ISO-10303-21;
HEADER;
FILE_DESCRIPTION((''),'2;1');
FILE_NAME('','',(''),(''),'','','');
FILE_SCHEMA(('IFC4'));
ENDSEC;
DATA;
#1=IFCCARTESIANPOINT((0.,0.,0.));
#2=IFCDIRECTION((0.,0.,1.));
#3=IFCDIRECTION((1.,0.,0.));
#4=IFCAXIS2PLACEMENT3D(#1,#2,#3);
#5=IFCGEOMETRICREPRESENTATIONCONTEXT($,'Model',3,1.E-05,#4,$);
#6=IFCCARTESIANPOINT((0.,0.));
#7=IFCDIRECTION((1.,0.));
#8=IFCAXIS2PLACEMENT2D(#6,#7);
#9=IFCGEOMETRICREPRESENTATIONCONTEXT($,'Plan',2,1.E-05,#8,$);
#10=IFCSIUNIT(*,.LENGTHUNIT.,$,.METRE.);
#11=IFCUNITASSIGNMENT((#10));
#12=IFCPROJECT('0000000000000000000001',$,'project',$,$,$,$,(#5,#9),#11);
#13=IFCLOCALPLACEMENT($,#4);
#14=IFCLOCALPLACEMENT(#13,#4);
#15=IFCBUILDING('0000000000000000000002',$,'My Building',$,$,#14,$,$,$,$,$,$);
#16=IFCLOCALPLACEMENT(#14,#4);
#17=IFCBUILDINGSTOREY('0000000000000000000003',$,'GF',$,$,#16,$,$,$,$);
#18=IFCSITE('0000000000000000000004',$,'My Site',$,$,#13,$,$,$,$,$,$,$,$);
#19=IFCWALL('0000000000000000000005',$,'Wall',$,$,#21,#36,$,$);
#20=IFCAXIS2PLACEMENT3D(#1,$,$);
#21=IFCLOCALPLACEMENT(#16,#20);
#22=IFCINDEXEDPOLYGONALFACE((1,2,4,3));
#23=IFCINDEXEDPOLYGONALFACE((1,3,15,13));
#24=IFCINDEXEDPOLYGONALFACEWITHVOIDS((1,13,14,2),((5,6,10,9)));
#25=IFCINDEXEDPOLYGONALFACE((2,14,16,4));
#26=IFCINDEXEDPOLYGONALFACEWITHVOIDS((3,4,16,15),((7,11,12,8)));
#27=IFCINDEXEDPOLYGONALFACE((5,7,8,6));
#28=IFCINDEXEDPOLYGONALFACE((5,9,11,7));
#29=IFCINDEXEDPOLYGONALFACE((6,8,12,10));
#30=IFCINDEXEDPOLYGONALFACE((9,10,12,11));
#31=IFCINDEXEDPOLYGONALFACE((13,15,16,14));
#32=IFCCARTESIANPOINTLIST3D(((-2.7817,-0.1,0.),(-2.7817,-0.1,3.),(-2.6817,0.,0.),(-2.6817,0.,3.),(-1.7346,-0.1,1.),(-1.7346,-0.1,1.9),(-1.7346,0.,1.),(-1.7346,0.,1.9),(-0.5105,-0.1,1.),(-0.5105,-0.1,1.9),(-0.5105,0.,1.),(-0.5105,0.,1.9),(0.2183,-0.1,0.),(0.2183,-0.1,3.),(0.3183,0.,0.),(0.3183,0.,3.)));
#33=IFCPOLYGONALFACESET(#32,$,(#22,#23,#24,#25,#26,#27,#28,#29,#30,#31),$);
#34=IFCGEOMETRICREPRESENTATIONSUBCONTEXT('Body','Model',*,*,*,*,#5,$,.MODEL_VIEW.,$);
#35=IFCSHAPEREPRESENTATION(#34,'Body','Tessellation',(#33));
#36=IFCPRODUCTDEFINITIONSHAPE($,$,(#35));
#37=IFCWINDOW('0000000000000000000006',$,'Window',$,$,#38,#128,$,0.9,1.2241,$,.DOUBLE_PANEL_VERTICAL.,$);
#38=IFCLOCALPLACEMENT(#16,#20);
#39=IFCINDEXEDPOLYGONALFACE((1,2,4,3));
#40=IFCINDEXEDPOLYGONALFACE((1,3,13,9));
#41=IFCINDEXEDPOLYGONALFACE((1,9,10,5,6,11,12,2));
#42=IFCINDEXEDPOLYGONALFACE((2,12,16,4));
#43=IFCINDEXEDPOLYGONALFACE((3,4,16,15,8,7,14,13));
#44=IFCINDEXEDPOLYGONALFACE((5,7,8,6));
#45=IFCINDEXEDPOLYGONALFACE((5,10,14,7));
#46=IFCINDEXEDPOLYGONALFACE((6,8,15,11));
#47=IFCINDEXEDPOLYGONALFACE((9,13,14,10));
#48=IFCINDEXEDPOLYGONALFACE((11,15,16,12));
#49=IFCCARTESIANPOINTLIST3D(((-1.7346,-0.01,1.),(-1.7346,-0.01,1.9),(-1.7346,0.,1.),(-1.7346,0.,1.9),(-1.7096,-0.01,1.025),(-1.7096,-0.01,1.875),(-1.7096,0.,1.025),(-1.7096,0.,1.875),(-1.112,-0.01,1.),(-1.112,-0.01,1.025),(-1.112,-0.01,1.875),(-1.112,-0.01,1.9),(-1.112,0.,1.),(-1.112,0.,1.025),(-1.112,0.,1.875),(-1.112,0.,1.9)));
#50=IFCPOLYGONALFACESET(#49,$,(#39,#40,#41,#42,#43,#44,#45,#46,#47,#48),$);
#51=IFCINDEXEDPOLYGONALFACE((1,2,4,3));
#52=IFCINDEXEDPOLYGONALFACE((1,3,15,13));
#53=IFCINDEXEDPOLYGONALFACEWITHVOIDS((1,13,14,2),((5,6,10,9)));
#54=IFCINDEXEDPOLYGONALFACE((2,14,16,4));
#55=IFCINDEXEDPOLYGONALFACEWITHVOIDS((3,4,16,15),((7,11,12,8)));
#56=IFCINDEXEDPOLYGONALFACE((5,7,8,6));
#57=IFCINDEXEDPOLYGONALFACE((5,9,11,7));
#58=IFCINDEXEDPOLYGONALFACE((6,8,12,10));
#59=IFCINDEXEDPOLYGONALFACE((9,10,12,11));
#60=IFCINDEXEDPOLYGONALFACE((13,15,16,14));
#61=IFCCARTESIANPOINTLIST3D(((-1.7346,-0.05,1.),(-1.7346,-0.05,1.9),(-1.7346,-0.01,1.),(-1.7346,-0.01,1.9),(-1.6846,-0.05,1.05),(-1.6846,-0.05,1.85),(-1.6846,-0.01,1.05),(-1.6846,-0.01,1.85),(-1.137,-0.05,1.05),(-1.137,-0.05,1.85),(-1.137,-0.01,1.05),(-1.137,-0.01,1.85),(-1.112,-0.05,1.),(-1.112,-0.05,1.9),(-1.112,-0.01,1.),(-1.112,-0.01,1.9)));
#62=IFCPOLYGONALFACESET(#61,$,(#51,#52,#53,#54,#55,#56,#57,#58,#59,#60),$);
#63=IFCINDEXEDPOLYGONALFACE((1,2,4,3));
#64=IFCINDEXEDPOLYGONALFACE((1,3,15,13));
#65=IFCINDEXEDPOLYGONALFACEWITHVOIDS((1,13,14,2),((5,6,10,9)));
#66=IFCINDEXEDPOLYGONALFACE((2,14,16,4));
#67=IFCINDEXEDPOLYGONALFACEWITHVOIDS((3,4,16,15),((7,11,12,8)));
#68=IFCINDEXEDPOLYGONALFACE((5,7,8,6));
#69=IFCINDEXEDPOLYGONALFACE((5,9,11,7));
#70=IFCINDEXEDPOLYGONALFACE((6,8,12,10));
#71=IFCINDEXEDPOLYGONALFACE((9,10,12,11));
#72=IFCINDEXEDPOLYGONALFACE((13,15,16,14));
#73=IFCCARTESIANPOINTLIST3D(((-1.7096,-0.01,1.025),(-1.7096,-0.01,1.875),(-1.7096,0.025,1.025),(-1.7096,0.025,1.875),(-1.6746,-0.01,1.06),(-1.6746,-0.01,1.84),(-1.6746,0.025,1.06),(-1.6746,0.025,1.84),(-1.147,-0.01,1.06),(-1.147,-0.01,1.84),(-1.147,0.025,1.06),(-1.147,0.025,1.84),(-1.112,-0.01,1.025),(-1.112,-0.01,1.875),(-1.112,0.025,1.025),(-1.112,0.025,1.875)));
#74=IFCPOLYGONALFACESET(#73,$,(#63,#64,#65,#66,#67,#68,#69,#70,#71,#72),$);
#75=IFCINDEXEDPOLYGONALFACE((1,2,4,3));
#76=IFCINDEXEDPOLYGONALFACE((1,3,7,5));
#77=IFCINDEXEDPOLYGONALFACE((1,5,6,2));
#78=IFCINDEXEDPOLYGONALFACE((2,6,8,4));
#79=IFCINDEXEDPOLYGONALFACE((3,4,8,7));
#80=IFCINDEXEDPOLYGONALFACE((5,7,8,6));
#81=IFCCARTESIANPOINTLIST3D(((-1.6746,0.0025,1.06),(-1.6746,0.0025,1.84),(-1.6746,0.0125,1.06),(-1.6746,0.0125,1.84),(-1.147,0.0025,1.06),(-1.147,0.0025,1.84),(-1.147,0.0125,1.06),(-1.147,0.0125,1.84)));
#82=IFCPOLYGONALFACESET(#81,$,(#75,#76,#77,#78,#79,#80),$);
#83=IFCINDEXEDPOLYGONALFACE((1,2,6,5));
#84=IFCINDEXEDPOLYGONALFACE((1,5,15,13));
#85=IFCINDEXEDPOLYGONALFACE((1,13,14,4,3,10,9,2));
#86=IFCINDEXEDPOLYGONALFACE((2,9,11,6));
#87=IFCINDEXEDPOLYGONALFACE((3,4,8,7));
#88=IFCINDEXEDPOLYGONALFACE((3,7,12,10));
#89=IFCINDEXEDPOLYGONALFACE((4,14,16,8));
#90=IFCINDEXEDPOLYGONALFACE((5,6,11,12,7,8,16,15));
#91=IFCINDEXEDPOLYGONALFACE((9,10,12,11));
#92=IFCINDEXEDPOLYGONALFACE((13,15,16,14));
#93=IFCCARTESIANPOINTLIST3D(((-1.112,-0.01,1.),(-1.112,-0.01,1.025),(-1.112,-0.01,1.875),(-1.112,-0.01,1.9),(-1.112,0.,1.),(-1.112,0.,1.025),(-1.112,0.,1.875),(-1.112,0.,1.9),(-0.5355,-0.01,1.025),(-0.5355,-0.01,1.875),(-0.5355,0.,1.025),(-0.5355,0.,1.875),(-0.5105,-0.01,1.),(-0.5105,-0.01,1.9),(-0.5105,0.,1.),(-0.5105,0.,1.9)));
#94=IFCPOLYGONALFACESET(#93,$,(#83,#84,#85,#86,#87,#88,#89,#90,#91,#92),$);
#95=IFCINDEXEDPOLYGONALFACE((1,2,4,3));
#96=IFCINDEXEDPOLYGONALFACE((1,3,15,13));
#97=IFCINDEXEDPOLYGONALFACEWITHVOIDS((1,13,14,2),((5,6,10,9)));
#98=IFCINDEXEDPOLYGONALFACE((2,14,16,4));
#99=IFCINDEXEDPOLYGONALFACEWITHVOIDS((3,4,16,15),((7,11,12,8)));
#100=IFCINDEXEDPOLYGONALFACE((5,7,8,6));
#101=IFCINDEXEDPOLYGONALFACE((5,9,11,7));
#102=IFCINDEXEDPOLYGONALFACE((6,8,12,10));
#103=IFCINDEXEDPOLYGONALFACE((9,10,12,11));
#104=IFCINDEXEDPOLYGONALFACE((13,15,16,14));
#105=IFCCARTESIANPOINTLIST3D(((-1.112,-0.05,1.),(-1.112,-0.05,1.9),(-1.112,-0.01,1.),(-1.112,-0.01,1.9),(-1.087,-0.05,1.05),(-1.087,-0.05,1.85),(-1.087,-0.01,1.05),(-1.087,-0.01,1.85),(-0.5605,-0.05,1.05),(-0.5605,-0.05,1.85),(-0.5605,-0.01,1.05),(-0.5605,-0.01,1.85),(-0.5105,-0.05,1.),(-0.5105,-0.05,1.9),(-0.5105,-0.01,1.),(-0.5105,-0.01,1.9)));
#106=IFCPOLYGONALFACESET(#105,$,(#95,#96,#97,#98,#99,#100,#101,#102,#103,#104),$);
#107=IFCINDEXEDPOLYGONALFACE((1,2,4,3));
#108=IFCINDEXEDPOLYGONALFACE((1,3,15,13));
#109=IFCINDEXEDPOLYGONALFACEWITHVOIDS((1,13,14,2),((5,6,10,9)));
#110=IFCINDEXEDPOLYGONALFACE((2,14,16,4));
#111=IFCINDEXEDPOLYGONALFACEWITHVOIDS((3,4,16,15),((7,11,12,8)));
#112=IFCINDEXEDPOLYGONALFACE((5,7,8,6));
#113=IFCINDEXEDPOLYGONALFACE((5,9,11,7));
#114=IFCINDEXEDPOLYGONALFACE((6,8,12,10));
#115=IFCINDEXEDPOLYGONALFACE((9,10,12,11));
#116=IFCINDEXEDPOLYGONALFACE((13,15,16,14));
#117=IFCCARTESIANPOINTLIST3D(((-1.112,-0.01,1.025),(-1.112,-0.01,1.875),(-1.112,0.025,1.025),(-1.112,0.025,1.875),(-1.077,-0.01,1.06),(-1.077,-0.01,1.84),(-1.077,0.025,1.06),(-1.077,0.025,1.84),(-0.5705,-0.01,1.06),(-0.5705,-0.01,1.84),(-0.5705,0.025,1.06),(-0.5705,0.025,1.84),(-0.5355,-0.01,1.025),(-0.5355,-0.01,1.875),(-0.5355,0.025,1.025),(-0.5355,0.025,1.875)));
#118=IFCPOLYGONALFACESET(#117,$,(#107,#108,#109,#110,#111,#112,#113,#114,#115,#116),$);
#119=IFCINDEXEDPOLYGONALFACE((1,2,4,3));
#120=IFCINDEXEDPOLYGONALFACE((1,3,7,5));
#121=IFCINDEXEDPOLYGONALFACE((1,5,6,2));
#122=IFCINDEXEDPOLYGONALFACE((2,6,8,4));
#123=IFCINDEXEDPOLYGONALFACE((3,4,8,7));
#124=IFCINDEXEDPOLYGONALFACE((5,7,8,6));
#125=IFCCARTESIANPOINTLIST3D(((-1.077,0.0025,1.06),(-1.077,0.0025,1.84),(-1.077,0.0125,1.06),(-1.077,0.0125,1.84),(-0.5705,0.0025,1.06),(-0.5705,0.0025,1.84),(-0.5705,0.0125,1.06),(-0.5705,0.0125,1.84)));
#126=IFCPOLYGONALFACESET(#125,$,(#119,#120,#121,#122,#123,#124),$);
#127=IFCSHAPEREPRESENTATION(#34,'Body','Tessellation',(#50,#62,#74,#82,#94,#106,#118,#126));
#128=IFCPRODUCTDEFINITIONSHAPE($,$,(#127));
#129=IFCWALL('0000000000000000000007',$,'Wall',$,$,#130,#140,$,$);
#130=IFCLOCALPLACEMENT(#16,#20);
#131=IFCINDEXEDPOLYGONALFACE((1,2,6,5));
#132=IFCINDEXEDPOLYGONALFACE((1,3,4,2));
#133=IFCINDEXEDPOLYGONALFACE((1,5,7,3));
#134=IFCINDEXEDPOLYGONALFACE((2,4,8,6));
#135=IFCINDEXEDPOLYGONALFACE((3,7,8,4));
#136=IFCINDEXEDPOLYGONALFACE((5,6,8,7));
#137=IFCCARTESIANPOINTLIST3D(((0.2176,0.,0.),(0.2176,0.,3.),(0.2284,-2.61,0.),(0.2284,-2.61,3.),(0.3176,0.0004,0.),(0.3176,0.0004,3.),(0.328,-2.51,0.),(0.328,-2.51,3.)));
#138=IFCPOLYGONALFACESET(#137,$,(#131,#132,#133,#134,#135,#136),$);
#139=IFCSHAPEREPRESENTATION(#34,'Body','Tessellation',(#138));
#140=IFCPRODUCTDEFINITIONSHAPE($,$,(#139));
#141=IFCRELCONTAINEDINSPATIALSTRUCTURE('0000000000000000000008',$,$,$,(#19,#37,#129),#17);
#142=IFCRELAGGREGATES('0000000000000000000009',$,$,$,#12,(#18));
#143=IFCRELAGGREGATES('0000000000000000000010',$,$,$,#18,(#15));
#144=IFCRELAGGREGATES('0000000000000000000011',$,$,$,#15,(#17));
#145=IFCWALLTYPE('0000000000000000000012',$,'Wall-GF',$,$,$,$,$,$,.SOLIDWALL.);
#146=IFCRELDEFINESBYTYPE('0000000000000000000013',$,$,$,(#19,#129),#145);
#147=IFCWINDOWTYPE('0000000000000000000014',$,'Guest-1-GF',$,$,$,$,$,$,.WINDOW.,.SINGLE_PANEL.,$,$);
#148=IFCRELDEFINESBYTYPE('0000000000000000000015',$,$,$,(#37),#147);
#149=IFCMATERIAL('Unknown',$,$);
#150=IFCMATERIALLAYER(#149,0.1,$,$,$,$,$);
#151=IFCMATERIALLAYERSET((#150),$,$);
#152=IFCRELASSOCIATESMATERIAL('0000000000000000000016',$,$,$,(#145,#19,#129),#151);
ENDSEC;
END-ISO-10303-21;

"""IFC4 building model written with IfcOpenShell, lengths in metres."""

from ifc_helpers import new_model, entity, si_unit, frame, origin_with_axes, origin_2d_with_axis, place, context, subcontext, project, spatial, line, indexed_curve, outline, extrude, shape, source, transform, mapped, material, layer, layer_set, layer_usage, type_object, type_shapes, element, fill, save


model = new_model("IFC4")

# Units and contexts
model_context = context("Model", 3, precision=1e-05, world=origin_with_axes())
plan_context = context("Plan", 2, precision=1e-05, world=origin_2d_with_axis())
body_context_1 = subcontext(model_context, "Body", "Model", "MODEL_VIEW")
body_context_2 = subcontext(plan_context, "Body", "Plan", "PLAN_VIEW")
ifc_project = project(units=[si_unit("LENGTHUNIT", "METRE")], contexts=[model_context, plan_context])

# Site, building, storey
site_placement = place(None, origin_with_axes())
site = spatial("IfcSite", under=ifc_project, at=site_placement, Name="My Site")
building_placement = place(site_placement, origin_with_axes())
building = spatial("IfcBuilding", under=site, at=building_placement, Name="My Building")
storey_placement = place(building_placement, origin_with_axes())
storey = spatial("IfcBuildingStorey", under=building, at=storey_placement, Name="GF")

# Shared definitions
ifc_material_1 = material(Name="Unknown")

# Shared definitions
ifc_layer_1 = layer(ifc_material_1, 0.1)
ifc_layer_set_1 = layer_set([ifc_layer_1])
wall_type = type_object("IfcWallType", Name="Wall-GF", PredefinedType="SOLIDWALL", material=ifc_layer_set_1)

# Wall, opening, window
ifc_layer_usage_1 = layer_usage(ifc_layer_set_1, "AXIS2", "POSITIVE", 0.0)
wall_1_placement = place(storey_placement, frame((-2.7817, -0.1, 0.0), z_axis=(0.0, 0.0, 1.0), x_axis=(1.0, 0.0, 0.0)))
wall_1 = element("IfcWall", 1, at=wall_1_placement, inside=storey, type_object=wall_type, material=ifc_layer_usage_1, Name="Wall", context=body_context_1, shape_type="SweptSolid", body=[
    extrude(outline(indexed_curve([(0.0, 0.0), (0.1, 0.1), (3.1, 0.1), (3.0, 0.0)], segments=[line(1, 2, 3, 4, 1)])), origin_with_axes(), (0.0, 0.0, 1.0), 3.0),
])
shared_shape_1 = source(origin_with_axes(), body_context_1, "Body", "SweptSolid", [
    extrude(outline(indexed_curve([(0.0, 0.0), (1.2241, 0.0), (1.2241, 0.9), (0.0, 0.9)], segments=[line(1, 2, 3, 4, 1)])), frame((0.0, -0.6, 0.0), z_axis=(0.0, -1.0, 0.0), x_axis=(1.0, 0.0, 0.0)), (0.0, 0.0, -1.0), 1.2),
])
opening_1_placement = place(wall_1_placement, frame((1.0471, 0.0, 1.0), z_axis=(0.0, 0.0, 1.0), x_axis=(1.0, 0.0, 0.0)))
opening_1 = element("IfcOpeningElement", 2, at=opening_1_placement, cuts=wall_1, PredefinedType="OPENING", context=body_context_1, shape_type="MappedRepresentation", body=[
    mapped(shared_shape_1, transform((0.0, 0.0, 0.0), x_axis=(1.0, 0.0, 0.0), y_axis=(0.0, 1.0, 0.0), z_axis=(0.0, 0.0, 1.0), scale=1.0)),
])
window_type_1 = type_object("IfcWindowType", Name="Guest-1-GF", PartitioningType="SINGLE_PANEL", PredefinedType="WINDOW")
shared_shape_2 = source(origin_with_axes(), body_context_1, "Body", "SweptSolid", [
    extrude(outline(indexed_curve([(0.6225, 0.0), (0.0, 0.0), (0.0, 0.9), (0.6225, 0.9), (0.6225, 0.875), (0.025, 0.875), (0.025, 0.025), (0.6225, 0.025)], segments=[line(1, 2, 3, 4, 5, 6, 7, 8, 1)])), frame((0.0, 0.09, 0.0), z_axis=(0.0, -1.0, 0.0), x_axis=(1.0, 0.0, 0.0)), (0.0, 0.0, -1.0), 0.01),
    extrude(outline(indexed_curve([(0.0, 0.0), (0.6225, 0.0), (0.6225, 0.9), (0.0, 0.9)], segments=[line(1, 2, 3, 4, 1)]), holes=[indexed_curve([(0.05, 0.05), (0.5975, 0.05), (0.5975, 0.85), (0.05, 0.85)], segments=[line(1, 2, 3, 4, 1)])]), frame((0.0, 0.05, 0.0), z_axis=(0.0, -1.0, 0.0), x_axis=(1.0, 0.0, 0.0)), (0.0, 0.0, -1.0), 0.04),
    extrude(outline(indexed_curve([(0.0, 0.0), (0.5975, 0.0), (0.5975, 0.85), (0.0, 0.85)], segments=[line(1, 2, 3, 4, 1)]), holes=[indexed_curve([(0.035, 0.035), (0.5625, 0.035), (0.5625, 0.815), (0.035, 0.815)], segments=[line(1, 2, 3, 4, 1)])]), frame((0.025, 0.09, 0.025), z_axis=(0.0, -1.0, 0.0), x_axis=(1.0, 0.0, 0.0)), (0.0, 0.0, -1.0), 0.035),
    extrude(outline(indexed_curve([(0.035, 0.035), (0.5625, 0.035), (0.5625, 0.815), (0.035, 0.815)], segments=[line(1, 2, 3, 4, 1)])), frame((0.025, 0.1025, 0.025), z_axis=(0.0, -1.0, 0.0), x_axis=(1.0, 0.0, 0.0)), (0.0, 0.0, -1.0), 0.01),
    extrude(outline(indexed_curve([(0.0, 0.9), (0.6016, 0.9), (0.6016, 0.0), (0.0, 0.0), (0.0, 0.025), (0.5766, 0.025), (0.5766, 0.875), (0.0, 0.875)], segments=[line(1, 2, 3, 4, 5, 6, 7, 8, 1)])), frame((0.6225, 0.09, 0.0), z_axis=(0.0, -1.0, 0.0), x_axis=(1.0, 0.0, 0.0)), (0.0, 0.0, -1.0), 0.01),
    extrude(outline(indexed_curve([(0.0, 0.0), (0.6016, 0.0), (0.6016, 0.9), (0.0, 0.9)], segments=[line(1, 2, 3, 4, 1)]), holes=[indexed_curve([(0.025, 0.05), (0.5516, 0.05), (0.5516, 0.85), (0.025, 0.85)], segments=[line(1, 2, 3, 4, 1)])]), frame((0.6225, 0.05, 0.0), z_axis=(0.0, -1.0, 0.0), x_axis=(1.0, 0.0, 0.0)), (0.0, 0.0, -1.0), 0.04),
    extrude(outline(indexed_curve([(0.0, 0.0), (0.5766, 0.0), (0.5766, 0.85), (0.0, 0.85)], segments=[line(1, 2, 3, 4, 1)]), holes=[indexed_curve([(0.035, 0.035), (0.5416, 0.035), (0.5416, 0.815), (0.035, 0.815)], segments=[line(1, 2, 3, 4, 1)])]), frame((0.6225, 0.09, 0.025), z_axis=(0.0, -1.0, 0.0), x_axis=(1.0, 0.0, 0.0)), (0.0, 0.0, -1.0), 0.035),
    extrude(outline(indexed_curve([(0.035, 0.035), (0.5416, 0.035), (0.5416, 0.815), (0.035, 0.815)], segments=[line(1, 2, 3, 4, 1)])), frame((0.6225, 0.1025, 0.025), z_axis=(0.0, -1.0, 0.0), x_axis=(1.0, 0.0, 0.0)), (0.0, 0.0, -1.0), 0.01),
])
shared_shape_3 = source(origin_with_axes(), body_context_2, "Body", "Curve2D", [
    entity("IfcIndexedPolyCurve", entity("IfcCartesianPointList2D", [[0.05, 0.05], [0.5975, 0.05]])),
    entity("IfcIndexedPolyCurve", entity("IfcCartesianPointList2D", [[0.0, 0.1], [0.025, 0.1], [0.025, 0.09], [0.05, 0.09], [0.05, 0.05], [0.0, 0.05]]), [entity("IfcLineIndex", [1, 2, 3, 4, 5, 6, 1])]),
    entity("IfcIndexedPolyCurve", entity("IfcCartesianPointList2D", [[0.6225, 0.1], [0.6225, 0.1], [0.6225, 0.09], [0.5975, 0.09], [0.5975, 0.05], [0.6225, 0.05]])),
    entity("IfcIndexedPolyCurve", entity("IfcCartesianPointList2D", [[0.025, 0.09], [0.06, 0.09], [0.06, 0.125], [0.025, 0.125]]), [entity("IfcLineIndex", [1, 2, 3, 4, 1])]),
    entity("IfcIndexedPolyCurve", entity("IfcCartesianPointList2D", [[0.6225, 0.09], [0.5875, 0.09], [0.5875, 0.125], [0.6225, 0.125]]), [entity("IfcLineIndex", [1, 2, 3, 4, 1])]),
    entity("IfcIndexedPolyCurve", entity("IfcCartesianPointList2D", [[0.06, 0.09], [0.5875, 0.09]])),
    entity("IfcIndexedPolyCurve", entity("IfcCartesianPointList2D", [[0.06, 0.125], [0.5875, 0.125]])),
    entity("IfcIndexedPolyCurve", entity("IfcCartesianPointList2D", [[0.06, 0.1075], [0.5875, 0.1075]])),
    entity("IfcIndexedPolyCurve", entity("IfcCartesianPointList2D", [[0.6475, 0.05], [1.1741, 0.05]])),
    entity("IfcIndexedPolyCurve", entity("IfcCartesianPointList2D", [[0.6225, 0.1], [0.6225, 0.1], [0.6225, 0.09], [0.6475, 0.09], [0.6475, 0.05], [0.6225, 0.05]])),
    entity("IfcIndexedPolyCurve", entity("IfcCartesianPointList2D", [[1.2241, 0.1], [1.1991, 0.1], [1.1991, 0.09], [1.1741, 0.09], [1.1741, 0.05], [1.2241, 0.05]]), [entity("IfcLineIndex", [1, 2, 3, 4, 5, 6, 1])]),
    entity("IfcIndexedPolyCurve", entity("IfcCartesianPointList2D", [[0.6225, 0.09], [0.6575, 0.09], [0.6575, 0.125], [0.6225, 0.125]]), [entity("IfcLineIndex", [1, 2, 3, 4, 1])]),
    entity("IfcIndexedPolyCurve", entity("IfcCartesianPointList2D", [[1.1991, 0.09], [1.1641, 0.09], [1.1641, 0.125], [1.1991, 0.125]]), [entity("IfcLineIndex", [1, 2, 3, 4, 1])]),
    entity("IfcIndexedPolyCurve", entity("IfcCartesianPointList2D", [[0.6575, 0.09], [1.1641, 0.09]])),
    entity("IfcIndexedPolyCurve", entity("IfcCartesianPointList2D", [[0.6575, 0.125], [1.1641, 0.125]])),
    entity("IfcIndexedPolyCurve", entity("IfcCartesianPointList2D", [[0.6575, 0.1075], [1.1641, 0.1075]])),
])
type_shapes(window_type_1, [shared_shape_2, shared_shape_3])
window_1_placement = place(opening_1_placement, origin_with_axes())
window_1 = element("IfcWindow", 3, at=window_1_placement, inside=storey, type_object=window_type_1, Name="Window", OverallHeight=0.9, OverallWidth=1.2241, PartitioningType="DOUBLE_PANEL_VERTICAL", shapes=[
    shape(body_context_1, "Body", "MappedRepresentation", [mapped(shared_shape_2, transform((0.0, 0.0, 0.0), x_axis=(1.0, 0.0, 0.0), y_axis=(0.0, 1.0, 0.0), z_axis=(0.0, 0.0, 1.0), scale=1.0))]),
    shape(body_context_2, "Body", "MappedRepresentation", [mapped(shared_shape_3, transform((0.0, 0.0, 0.0), x_axis=(1.0, 0.0, 0.0), y_axis=(0.0, 1.0, 0.0), z_axis=(0.0, 0.0, 1.0), scale=1.0))]),
])
fill(opening_1, window_1)

# Wall
ifc_layer_usage_2 = layer_usage(ifc_layer_set_1, "AXIS2", "POSITIVE", 0.0)
wall_2_placement = place(storey_placement, frame((0.2176, 0.0, 0.0), z_axis=(0.0, 0.0, 1.0), x_axis=(0.004129, -0.999991, 0.0)))
element("IfcWall", 4, at=wall_2_placement, inside=storey, type_object=wall_type, material=ifc_layer_usage_2, Name="Wall", context=body_context_1, shape_type="SweptSolid", body=[
    extrude(outline(indexed_curve([(0.0, 0.0), (0.0, 0.1), (2.5104, 0.1), (2.61, 0.0)], segments=[line(1, 2, 3, 4, 1)])), origin_with_axes(), (0.0, 0.0, 1.0), 3.0),
])

save(model, "model.ifc")
